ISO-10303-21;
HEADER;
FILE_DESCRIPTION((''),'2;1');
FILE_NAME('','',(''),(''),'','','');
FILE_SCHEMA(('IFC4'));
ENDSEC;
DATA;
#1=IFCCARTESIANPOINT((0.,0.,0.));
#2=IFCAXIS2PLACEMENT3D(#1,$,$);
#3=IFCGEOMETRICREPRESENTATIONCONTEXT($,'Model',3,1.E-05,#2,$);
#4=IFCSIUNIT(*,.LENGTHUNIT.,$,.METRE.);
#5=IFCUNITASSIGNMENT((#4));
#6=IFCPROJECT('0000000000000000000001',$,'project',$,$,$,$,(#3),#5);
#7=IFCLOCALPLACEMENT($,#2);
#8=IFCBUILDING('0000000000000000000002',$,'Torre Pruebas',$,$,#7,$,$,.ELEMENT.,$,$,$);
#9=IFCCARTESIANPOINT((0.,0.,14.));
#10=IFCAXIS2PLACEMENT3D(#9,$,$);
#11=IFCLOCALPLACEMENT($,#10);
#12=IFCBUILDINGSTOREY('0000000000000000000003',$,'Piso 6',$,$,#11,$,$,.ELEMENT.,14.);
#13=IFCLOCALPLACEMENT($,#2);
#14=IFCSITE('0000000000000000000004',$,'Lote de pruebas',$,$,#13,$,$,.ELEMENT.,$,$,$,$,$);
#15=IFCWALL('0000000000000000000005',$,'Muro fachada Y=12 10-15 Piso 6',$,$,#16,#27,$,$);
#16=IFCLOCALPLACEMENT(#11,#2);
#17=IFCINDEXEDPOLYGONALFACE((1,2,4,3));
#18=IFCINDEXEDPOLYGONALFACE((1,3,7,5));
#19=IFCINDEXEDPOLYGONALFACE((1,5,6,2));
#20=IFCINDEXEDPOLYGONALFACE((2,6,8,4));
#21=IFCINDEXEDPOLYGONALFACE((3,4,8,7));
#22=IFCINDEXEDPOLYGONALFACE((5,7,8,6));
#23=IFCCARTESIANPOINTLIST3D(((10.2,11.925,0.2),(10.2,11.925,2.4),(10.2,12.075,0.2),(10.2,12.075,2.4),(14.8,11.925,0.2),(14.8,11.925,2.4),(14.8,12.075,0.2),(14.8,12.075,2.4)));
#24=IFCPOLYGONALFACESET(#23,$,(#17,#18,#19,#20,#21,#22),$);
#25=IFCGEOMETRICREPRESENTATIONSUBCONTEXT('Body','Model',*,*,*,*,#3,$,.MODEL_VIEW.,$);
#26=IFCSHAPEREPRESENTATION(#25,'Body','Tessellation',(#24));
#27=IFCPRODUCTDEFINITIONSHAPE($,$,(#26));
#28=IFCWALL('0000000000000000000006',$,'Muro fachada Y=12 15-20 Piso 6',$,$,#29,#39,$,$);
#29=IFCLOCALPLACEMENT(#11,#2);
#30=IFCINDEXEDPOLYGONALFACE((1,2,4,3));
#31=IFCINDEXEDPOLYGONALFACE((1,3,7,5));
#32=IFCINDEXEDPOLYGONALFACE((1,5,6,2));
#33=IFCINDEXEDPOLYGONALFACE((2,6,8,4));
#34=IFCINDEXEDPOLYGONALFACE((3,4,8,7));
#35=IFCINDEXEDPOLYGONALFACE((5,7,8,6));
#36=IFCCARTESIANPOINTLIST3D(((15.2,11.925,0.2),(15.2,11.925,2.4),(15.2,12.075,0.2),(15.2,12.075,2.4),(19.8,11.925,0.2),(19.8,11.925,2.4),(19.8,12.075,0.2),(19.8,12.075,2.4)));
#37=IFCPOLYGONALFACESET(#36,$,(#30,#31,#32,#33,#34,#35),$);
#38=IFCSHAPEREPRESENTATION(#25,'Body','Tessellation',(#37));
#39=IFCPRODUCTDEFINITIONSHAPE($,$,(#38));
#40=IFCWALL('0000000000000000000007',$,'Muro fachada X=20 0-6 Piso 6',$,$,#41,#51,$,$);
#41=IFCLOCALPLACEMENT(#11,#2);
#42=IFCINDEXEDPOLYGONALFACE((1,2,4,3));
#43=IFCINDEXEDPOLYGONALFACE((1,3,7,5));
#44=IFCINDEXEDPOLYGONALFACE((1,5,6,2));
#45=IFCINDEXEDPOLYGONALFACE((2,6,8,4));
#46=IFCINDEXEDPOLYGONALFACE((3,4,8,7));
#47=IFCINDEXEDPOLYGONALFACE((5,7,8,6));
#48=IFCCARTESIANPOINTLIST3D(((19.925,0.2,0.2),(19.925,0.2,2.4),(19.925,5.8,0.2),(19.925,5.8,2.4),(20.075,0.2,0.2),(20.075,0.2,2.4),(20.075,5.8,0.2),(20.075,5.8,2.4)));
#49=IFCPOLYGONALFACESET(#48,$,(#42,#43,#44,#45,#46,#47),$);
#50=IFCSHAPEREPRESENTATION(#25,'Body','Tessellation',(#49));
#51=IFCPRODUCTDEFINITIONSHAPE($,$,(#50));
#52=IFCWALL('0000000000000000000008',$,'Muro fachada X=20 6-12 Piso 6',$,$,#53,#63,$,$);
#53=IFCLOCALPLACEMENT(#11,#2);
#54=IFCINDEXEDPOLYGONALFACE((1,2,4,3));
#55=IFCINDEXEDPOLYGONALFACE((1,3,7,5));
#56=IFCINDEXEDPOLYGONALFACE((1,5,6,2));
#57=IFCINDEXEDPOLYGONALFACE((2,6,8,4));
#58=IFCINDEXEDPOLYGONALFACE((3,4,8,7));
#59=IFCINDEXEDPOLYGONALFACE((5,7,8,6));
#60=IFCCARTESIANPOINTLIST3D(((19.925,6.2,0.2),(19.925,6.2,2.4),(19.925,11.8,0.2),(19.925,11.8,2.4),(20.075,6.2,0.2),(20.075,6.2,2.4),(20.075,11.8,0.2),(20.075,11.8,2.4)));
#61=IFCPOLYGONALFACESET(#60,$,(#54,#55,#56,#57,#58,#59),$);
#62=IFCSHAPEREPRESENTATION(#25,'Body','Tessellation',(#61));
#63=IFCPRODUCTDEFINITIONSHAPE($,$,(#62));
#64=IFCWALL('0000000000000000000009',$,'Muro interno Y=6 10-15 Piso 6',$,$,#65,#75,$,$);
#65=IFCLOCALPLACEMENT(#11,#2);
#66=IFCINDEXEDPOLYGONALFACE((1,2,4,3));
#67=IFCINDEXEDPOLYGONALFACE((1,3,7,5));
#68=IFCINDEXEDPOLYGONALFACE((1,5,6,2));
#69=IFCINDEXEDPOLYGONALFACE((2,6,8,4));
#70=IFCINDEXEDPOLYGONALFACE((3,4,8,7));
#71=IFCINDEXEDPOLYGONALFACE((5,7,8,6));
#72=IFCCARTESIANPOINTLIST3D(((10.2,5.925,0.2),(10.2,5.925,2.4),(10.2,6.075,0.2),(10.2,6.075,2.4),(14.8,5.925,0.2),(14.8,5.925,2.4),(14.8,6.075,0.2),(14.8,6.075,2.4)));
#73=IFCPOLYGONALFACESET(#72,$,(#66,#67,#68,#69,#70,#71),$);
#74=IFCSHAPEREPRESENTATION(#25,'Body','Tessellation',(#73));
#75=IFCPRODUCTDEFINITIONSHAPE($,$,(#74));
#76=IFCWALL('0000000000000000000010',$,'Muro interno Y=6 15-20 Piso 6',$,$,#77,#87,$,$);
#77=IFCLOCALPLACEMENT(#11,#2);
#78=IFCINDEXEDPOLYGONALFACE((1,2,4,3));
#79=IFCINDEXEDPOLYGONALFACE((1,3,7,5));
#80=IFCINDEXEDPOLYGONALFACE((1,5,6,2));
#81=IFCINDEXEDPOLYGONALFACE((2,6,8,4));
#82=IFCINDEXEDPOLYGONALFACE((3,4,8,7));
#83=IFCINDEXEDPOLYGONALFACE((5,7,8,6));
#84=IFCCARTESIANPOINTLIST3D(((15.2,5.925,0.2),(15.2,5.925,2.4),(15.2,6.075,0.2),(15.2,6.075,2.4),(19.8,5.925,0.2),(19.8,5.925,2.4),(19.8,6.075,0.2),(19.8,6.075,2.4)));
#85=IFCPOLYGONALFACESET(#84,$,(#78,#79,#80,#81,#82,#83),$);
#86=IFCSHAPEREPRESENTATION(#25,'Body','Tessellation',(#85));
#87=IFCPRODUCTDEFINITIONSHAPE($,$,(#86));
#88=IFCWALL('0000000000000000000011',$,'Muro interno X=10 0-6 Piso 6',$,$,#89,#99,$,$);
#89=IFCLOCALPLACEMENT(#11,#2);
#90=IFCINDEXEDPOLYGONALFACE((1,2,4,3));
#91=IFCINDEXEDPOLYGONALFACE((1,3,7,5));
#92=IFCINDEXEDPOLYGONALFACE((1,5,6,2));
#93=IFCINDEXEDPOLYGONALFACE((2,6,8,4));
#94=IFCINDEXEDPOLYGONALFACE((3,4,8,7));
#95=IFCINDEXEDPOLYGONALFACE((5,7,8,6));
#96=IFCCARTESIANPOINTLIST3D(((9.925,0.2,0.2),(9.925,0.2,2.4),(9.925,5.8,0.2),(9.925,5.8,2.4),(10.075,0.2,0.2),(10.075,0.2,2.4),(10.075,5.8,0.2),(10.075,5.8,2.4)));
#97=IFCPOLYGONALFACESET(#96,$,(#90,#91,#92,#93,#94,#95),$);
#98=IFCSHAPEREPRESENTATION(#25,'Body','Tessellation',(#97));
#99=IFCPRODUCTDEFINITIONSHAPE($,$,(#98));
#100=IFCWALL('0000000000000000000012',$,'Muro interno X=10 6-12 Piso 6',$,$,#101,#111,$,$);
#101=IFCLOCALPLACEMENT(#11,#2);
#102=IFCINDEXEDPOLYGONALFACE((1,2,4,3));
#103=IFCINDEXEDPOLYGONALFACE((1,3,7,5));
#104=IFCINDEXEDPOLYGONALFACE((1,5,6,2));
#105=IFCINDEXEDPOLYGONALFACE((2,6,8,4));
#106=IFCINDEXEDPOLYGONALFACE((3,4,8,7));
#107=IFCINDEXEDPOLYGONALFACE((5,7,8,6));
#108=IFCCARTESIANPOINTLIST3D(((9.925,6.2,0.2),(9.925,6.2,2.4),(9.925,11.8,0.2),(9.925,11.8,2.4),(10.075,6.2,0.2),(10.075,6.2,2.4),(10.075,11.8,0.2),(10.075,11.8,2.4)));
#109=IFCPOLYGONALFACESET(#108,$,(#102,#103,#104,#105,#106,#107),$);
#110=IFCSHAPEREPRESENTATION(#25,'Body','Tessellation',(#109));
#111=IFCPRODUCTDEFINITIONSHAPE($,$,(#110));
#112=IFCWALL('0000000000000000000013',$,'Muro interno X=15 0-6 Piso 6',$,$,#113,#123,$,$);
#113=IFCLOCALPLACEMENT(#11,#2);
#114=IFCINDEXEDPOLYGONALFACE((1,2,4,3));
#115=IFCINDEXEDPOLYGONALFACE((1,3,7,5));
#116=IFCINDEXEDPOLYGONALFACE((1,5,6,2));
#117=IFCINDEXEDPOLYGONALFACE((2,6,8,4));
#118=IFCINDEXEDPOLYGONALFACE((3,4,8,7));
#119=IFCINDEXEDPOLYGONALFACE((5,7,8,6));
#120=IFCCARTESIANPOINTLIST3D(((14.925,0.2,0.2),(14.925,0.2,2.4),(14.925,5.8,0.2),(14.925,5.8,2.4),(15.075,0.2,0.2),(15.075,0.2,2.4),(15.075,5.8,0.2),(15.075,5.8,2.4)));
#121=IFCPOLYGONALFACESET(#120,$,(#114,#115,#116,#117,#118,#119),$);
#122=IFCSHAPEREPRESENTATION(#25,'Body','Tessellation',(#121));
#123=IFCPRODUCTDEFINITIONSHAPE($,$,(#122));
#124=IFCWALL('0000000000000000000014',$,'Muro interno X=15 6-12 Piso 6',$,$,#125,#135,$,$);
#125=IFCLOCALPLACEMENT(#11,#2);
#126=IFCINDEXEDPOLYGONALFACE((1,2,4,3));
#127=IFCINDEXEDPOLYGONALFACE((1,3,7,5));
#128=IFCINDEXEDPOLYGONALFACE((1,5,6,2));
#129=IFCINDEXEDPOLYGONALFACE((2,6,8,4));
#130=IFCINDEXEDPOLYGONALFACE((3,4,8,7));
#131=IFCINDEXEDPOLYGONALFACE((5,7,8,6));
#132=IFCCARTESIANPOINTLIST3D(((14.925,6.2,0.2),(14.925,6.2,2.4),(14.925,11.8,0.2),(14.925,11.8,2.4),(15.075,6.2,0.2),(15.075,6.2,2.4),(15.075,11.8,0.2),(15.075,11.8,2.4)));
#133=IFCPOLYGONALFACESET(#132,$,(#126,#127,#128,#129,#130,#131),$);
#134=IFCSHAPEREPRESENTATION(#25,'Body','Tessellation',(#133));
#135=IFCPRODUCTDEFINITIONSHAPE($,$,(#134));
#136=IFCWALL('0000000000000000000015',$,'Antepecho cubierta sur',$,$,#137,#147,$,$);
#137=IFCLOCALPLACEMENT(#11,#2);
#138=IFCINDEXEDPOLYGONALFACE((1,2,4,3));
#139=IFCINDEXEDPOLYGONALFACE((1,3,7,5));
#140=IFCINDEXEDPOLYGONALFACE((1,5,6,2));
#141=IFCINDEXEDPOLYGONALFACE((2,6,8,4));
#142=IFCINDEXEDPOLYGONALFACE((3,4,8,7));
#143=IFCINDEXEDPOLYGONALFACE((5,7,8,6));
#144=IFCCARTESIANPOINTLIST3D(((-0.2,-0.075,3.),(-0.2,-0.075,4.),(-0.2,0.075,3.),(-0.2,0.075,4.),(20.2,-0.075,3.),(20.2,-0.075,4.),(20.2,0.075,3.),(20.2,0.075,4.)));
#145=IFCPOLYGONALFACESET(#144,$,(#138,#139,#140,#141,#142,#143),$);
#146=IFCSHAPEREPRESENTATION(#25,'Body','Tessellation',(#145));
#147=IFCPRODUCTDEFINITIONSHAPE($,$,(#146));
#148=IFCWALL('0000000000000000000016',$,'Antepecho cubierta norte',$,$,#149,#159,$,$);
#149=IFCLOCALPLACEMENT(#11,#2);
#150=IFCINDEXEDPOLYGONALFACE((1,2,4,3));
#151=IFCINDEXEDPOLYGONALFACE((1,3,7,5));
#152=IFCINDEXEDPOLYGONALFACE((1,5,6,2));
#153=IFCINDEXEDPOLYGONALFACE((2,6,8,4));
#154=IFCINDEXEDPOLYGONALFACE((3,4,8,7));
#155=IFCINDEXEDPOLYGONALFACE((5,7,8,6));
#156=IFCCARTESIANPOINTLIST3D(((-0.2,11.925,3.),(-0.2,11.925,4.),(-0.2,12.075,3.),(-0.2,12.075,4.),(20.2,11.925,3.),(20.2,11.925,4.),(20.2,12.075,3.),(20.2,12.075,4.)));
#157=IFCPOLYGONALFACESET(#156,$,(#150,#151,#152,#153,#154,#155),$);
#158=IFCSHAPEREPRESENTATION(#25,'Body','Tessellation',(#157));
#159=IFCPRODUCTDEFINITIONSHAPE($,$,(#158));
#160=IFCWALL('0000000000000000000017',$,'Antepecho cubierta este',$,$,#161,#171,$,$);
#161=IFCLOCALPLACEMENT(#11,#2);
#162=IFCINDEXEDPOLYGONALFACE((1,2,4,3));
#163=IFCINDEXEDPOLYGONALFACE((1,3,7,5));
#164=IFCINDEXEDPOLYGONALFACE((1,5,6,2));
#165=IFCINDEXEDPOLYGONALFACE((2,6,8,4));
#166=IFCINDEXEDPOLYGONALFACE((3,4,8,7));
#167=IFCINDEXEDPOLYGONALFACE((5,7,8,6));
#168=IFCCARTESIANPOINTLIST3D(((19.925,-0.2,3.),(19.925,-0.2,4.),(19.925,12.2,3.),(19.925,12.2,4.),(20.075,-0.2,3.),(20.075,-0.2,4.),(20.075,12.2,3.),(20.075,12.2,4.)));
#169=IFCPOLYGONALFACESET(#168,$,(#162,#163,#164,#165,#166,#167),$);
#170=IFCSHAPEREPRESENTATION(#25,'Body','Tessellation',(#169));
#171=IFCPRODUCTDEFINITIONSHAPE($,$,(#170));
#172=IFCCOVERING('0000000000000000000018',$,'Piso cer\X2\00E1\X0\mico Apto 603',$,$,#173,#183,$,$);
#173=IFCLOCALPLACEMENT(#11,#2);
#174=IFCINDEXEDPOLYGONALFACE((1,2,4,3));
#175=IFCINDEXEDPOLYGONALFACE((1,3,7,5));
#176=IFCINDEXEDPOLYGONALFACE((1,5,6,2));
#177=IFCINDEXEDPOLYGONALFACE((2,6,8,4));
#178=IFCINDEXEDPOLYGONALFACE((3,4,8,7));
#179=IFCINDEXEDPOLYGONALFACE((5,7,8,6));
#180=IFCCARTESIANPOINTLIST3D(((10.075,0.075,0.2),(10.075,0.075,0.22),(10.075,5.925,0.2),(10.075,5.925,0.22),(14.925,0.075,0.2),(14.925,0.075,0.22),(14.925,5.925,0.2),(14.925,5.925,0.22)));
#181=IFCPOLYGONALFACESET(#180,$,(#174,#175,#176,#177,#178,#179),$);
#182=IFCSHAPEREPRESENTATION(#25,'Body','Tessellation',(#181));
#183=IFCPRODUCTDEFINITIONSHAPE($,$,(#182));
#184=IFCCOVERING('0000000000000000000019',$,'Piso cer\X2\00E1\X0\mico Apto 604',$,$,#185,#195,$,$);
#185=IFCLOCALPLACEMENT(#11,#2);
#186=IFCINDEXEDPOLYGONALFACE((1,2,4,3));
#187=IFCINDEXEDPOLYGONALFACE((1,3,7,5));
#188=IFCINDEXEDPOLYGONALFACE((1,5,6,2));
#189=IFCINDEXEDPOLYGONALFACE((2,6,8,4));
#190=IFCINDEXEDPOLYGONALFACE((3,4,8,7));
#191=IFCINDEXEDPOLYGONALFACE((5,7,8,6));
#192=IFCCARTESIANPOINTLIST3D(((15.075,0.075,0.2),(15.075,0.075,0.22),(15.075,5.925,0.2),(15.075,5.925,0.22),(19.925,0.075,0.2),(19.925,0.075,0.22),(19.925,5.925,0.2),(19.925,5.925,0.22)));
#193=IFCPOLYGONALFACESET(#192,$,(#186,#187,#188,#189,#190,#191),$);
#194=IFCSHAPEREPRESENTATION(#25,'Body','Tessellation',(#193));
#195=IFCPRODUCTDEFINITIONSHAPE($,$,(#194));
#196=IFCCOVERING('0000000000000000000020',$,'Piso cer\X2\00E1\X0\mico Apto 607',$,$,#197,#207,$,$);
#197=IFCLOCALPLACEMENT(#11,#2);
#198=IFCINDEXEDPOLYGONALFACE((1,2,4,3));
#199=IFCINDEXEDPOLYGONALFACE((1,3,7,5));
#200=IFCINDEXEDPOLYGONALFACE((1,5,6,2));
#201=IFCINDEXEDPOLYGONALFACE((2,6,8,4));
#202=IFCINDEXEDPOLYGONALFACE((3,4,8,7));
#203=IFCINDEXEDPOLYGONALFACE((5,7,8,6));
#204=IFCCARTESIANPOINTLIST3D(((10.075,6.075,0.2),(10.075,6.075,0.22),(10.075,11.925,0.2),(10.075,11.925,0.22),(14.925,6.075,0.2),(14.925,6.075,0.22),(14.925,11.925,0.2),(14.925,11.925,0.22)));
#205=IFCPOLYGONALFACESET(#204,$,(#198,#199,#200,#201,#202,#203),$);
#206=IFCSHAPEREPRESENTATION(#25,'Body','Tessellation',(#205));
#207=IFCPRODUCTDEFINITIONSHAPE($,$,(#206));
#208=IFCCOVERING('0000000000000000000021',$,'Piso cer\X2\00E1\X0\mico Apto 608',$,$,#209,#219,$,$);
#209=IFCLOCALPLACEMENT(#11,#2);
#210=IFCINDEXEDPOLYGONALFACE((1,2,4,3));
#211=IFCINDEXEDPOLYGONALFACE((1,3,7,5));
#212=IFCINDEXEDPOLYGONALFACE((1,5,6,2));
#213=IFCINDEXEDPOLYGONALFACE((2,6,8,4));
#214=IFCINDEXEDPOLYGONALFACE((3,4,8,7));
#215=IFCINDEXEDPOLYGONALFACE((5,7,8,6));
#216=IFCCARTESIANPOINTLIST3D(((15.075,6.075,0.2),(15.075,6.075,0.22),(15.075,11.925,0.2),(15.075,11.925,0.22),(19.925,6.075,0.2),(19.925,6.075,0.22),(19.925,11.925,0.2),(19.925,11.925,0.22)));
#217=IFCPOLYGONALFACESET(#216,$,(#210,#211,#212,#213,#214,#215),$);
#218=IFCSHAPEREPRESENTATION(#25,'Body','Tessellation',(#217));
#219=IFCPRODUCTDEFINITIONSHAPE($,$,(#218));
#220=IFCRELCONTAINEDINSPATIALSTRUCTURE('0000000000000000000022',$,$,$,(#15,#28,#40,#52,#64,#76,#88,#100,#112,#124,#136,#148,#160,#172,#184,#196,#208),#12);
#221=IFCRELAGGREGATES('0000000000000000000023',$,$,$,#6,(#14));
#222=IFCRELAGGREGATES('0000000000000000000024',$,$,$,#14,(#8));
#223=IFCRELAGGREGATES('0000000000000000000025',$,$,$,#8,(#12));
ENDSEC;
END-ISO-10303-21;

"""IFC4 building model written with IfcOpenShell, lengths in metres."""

from ifc_helpers import new_model, si_unit, frame, origin, origin_2d, place, context, subcontext, project, spatial, rectangle, extrude, element, save


model = new_model("IFC4")

# Units and contexts
model_context = context("Model", 3, precision=1e-05, world=origin())
body_context = subcontext(model_context, "Body", "Model", "MODEL_VIEW")
ifc_project = project(units=[si_unit("LENGTHUNIT", "METRE")], contexts=[model_context])

# Site, building, storey
site_placement = place(None, origin())
site = spatial("IfcSite", under=ifc_project, at=site_placement, Name="Lote de pruebas", CompositionType="ELEMENT")
building_placement = place(None, origin())
building = spatial("IfcBuilding", under=site, at=building_placement, Name="Torre Pruebas", CompositionType="ELEMENT")
storey_placement = place(None, frame((0.0, 0.0, 14.0)))
storey = spatial("IfcBuildingStorey", under=building, at=storey_placement, Name="Piso 6", CompositionType="ELEMENT", Elevation=14.0)

# Walls
for number, where, name in (
    (1, (12.5, 12.0, 14.2), "Muro fachada Y=12 10-15 Piso 6"),
    (2, (17.5, 12.0, 14.2), "Muro fachada Y=12 15-20 Piso 6"),
):
    element("IfcWall", number, at=place(None, frame(where)), inside=storey, Name=name, context=body_context, shape_type="SweptSolid", body=[
        extrude(rectangle(XDim=4.6, YDim=0.15, at=origin_2d()), origin(), (0.0, 0.0, 1.0), 2.2),
    ])
for number, where, name in (
    (3, (20.0, 3.0, 14.2), "Muro fachada X=20 0-6 Piso 6"),
    (4, (20.0, 9.0, 14.2), "Muro fachada X=20 6-12 Piso 6"),
):
    element("IfcWall", number, at=place(None, frame(where)), inside=storey, Name=name, context=body_context, shape_type="SweptSolid", body=[
        extrude(rectangle(XDim=0.15, YDim=5.6, at=origin_2d()), origin(), (0.0, 0.0, 1.0), 2.2),
    ])
for number, where, name in (
    (5, (12.5, 6.0, 14.2), "Muro interno Y=6 10-15 Piso 6"),
    (6, (17.5, 6.0, 14.2), "Muro interno Y=6 15-20 Piso 6"),
):
    element("IfcWall", number, at=place(None, frame(where)), inside=storey, Name=name, context=body_context, shape_type="SweptSolid", body=[
        extrude(rectangle(XDim=4.6, YDim=0.15, at=origin_2d()), origin(), (0.0, 0.0, 1.0), 2.2),
    ])
for number, where, name in (
    (7, (10.0, 3.0, 14.2), "Muro interno X=10 0-6 Piso 6"),
    (8, (10.0, 9.0, 14.2), "Muro interno X=10 6-12 Piso 6"),
    (9, (15.0, 3.0, 14.2), "Muro interno X=15 0-6 Piso 6"),
    (10, (15.0, 9.0, 14.2), "Muro interno X=15 6-12 Piso 6"),
):
    element("IfcWall", number, at=place(None, frame(where)), inside=storey, Name=name, context=body_context, shape_type="SweptSolid", body=[
        extrude(rectangle(XDim=0.15, YDim=5.6, at=origin_2d()), origin(), (0.0, 0.0, 1.0), 2.2),
    ])
for number, where, name in (
    (11, (10.0, 0.0, 17.0), "Antepecho cubierta sur"),
    (12, (10.0, 12.0, 17.0), "Antepecho cubierta norte"),
):
    element("IfcWall", number, at=place(None, frame(where)), inside=storey, Name=name, context=body_context, shape_type="SweptSolid", body=[
        extrude(rectangle(XDim=20.4, YDim=0.15, at=origin_2d()), origin(), (0.0, 0.0, 1.0), 1.0),
    ])
wall_placement = place(None, frame((20.0, 6.0, 17.0)))
element("IfcWall", 13, at=wall_placement, inside=storey, Name="Antepecho cubierta este", context=body_context, shape_type="SweptSolid", body=[
    extrude(rectangle(XDim=0.15, YDim=12.4, at=origin_2d()), origin(), (0.0, 0.0, 1.0), 1.0),
])

# Coverings
for number, where, name in (
    (14, (12.5, 3.0, 14.2), "Piso cerámico Apto 603"),
    (15, (17.5, 3.0, 14.2), "Piso cerámico Apto 604"),
    (16, (12.5, 9.0, 14.2), "Piso cerámico Apto 607"),
    (17, (17.5, 9.0, 14.2), "Piso cerámico Apto 608"),
):
    element("IfcCovering", number, at=place(None, frame(where)), inside=storey, Name=name, context=body_context, shape_type="SweptSolid", body=[
        extrude(rectangle(XDim=4.85, YDim=5.85, at=origin_2d()), origin(), (0.0, 0.0, 1.0), 0.02),
    ])

save(model, "model.ifc")
